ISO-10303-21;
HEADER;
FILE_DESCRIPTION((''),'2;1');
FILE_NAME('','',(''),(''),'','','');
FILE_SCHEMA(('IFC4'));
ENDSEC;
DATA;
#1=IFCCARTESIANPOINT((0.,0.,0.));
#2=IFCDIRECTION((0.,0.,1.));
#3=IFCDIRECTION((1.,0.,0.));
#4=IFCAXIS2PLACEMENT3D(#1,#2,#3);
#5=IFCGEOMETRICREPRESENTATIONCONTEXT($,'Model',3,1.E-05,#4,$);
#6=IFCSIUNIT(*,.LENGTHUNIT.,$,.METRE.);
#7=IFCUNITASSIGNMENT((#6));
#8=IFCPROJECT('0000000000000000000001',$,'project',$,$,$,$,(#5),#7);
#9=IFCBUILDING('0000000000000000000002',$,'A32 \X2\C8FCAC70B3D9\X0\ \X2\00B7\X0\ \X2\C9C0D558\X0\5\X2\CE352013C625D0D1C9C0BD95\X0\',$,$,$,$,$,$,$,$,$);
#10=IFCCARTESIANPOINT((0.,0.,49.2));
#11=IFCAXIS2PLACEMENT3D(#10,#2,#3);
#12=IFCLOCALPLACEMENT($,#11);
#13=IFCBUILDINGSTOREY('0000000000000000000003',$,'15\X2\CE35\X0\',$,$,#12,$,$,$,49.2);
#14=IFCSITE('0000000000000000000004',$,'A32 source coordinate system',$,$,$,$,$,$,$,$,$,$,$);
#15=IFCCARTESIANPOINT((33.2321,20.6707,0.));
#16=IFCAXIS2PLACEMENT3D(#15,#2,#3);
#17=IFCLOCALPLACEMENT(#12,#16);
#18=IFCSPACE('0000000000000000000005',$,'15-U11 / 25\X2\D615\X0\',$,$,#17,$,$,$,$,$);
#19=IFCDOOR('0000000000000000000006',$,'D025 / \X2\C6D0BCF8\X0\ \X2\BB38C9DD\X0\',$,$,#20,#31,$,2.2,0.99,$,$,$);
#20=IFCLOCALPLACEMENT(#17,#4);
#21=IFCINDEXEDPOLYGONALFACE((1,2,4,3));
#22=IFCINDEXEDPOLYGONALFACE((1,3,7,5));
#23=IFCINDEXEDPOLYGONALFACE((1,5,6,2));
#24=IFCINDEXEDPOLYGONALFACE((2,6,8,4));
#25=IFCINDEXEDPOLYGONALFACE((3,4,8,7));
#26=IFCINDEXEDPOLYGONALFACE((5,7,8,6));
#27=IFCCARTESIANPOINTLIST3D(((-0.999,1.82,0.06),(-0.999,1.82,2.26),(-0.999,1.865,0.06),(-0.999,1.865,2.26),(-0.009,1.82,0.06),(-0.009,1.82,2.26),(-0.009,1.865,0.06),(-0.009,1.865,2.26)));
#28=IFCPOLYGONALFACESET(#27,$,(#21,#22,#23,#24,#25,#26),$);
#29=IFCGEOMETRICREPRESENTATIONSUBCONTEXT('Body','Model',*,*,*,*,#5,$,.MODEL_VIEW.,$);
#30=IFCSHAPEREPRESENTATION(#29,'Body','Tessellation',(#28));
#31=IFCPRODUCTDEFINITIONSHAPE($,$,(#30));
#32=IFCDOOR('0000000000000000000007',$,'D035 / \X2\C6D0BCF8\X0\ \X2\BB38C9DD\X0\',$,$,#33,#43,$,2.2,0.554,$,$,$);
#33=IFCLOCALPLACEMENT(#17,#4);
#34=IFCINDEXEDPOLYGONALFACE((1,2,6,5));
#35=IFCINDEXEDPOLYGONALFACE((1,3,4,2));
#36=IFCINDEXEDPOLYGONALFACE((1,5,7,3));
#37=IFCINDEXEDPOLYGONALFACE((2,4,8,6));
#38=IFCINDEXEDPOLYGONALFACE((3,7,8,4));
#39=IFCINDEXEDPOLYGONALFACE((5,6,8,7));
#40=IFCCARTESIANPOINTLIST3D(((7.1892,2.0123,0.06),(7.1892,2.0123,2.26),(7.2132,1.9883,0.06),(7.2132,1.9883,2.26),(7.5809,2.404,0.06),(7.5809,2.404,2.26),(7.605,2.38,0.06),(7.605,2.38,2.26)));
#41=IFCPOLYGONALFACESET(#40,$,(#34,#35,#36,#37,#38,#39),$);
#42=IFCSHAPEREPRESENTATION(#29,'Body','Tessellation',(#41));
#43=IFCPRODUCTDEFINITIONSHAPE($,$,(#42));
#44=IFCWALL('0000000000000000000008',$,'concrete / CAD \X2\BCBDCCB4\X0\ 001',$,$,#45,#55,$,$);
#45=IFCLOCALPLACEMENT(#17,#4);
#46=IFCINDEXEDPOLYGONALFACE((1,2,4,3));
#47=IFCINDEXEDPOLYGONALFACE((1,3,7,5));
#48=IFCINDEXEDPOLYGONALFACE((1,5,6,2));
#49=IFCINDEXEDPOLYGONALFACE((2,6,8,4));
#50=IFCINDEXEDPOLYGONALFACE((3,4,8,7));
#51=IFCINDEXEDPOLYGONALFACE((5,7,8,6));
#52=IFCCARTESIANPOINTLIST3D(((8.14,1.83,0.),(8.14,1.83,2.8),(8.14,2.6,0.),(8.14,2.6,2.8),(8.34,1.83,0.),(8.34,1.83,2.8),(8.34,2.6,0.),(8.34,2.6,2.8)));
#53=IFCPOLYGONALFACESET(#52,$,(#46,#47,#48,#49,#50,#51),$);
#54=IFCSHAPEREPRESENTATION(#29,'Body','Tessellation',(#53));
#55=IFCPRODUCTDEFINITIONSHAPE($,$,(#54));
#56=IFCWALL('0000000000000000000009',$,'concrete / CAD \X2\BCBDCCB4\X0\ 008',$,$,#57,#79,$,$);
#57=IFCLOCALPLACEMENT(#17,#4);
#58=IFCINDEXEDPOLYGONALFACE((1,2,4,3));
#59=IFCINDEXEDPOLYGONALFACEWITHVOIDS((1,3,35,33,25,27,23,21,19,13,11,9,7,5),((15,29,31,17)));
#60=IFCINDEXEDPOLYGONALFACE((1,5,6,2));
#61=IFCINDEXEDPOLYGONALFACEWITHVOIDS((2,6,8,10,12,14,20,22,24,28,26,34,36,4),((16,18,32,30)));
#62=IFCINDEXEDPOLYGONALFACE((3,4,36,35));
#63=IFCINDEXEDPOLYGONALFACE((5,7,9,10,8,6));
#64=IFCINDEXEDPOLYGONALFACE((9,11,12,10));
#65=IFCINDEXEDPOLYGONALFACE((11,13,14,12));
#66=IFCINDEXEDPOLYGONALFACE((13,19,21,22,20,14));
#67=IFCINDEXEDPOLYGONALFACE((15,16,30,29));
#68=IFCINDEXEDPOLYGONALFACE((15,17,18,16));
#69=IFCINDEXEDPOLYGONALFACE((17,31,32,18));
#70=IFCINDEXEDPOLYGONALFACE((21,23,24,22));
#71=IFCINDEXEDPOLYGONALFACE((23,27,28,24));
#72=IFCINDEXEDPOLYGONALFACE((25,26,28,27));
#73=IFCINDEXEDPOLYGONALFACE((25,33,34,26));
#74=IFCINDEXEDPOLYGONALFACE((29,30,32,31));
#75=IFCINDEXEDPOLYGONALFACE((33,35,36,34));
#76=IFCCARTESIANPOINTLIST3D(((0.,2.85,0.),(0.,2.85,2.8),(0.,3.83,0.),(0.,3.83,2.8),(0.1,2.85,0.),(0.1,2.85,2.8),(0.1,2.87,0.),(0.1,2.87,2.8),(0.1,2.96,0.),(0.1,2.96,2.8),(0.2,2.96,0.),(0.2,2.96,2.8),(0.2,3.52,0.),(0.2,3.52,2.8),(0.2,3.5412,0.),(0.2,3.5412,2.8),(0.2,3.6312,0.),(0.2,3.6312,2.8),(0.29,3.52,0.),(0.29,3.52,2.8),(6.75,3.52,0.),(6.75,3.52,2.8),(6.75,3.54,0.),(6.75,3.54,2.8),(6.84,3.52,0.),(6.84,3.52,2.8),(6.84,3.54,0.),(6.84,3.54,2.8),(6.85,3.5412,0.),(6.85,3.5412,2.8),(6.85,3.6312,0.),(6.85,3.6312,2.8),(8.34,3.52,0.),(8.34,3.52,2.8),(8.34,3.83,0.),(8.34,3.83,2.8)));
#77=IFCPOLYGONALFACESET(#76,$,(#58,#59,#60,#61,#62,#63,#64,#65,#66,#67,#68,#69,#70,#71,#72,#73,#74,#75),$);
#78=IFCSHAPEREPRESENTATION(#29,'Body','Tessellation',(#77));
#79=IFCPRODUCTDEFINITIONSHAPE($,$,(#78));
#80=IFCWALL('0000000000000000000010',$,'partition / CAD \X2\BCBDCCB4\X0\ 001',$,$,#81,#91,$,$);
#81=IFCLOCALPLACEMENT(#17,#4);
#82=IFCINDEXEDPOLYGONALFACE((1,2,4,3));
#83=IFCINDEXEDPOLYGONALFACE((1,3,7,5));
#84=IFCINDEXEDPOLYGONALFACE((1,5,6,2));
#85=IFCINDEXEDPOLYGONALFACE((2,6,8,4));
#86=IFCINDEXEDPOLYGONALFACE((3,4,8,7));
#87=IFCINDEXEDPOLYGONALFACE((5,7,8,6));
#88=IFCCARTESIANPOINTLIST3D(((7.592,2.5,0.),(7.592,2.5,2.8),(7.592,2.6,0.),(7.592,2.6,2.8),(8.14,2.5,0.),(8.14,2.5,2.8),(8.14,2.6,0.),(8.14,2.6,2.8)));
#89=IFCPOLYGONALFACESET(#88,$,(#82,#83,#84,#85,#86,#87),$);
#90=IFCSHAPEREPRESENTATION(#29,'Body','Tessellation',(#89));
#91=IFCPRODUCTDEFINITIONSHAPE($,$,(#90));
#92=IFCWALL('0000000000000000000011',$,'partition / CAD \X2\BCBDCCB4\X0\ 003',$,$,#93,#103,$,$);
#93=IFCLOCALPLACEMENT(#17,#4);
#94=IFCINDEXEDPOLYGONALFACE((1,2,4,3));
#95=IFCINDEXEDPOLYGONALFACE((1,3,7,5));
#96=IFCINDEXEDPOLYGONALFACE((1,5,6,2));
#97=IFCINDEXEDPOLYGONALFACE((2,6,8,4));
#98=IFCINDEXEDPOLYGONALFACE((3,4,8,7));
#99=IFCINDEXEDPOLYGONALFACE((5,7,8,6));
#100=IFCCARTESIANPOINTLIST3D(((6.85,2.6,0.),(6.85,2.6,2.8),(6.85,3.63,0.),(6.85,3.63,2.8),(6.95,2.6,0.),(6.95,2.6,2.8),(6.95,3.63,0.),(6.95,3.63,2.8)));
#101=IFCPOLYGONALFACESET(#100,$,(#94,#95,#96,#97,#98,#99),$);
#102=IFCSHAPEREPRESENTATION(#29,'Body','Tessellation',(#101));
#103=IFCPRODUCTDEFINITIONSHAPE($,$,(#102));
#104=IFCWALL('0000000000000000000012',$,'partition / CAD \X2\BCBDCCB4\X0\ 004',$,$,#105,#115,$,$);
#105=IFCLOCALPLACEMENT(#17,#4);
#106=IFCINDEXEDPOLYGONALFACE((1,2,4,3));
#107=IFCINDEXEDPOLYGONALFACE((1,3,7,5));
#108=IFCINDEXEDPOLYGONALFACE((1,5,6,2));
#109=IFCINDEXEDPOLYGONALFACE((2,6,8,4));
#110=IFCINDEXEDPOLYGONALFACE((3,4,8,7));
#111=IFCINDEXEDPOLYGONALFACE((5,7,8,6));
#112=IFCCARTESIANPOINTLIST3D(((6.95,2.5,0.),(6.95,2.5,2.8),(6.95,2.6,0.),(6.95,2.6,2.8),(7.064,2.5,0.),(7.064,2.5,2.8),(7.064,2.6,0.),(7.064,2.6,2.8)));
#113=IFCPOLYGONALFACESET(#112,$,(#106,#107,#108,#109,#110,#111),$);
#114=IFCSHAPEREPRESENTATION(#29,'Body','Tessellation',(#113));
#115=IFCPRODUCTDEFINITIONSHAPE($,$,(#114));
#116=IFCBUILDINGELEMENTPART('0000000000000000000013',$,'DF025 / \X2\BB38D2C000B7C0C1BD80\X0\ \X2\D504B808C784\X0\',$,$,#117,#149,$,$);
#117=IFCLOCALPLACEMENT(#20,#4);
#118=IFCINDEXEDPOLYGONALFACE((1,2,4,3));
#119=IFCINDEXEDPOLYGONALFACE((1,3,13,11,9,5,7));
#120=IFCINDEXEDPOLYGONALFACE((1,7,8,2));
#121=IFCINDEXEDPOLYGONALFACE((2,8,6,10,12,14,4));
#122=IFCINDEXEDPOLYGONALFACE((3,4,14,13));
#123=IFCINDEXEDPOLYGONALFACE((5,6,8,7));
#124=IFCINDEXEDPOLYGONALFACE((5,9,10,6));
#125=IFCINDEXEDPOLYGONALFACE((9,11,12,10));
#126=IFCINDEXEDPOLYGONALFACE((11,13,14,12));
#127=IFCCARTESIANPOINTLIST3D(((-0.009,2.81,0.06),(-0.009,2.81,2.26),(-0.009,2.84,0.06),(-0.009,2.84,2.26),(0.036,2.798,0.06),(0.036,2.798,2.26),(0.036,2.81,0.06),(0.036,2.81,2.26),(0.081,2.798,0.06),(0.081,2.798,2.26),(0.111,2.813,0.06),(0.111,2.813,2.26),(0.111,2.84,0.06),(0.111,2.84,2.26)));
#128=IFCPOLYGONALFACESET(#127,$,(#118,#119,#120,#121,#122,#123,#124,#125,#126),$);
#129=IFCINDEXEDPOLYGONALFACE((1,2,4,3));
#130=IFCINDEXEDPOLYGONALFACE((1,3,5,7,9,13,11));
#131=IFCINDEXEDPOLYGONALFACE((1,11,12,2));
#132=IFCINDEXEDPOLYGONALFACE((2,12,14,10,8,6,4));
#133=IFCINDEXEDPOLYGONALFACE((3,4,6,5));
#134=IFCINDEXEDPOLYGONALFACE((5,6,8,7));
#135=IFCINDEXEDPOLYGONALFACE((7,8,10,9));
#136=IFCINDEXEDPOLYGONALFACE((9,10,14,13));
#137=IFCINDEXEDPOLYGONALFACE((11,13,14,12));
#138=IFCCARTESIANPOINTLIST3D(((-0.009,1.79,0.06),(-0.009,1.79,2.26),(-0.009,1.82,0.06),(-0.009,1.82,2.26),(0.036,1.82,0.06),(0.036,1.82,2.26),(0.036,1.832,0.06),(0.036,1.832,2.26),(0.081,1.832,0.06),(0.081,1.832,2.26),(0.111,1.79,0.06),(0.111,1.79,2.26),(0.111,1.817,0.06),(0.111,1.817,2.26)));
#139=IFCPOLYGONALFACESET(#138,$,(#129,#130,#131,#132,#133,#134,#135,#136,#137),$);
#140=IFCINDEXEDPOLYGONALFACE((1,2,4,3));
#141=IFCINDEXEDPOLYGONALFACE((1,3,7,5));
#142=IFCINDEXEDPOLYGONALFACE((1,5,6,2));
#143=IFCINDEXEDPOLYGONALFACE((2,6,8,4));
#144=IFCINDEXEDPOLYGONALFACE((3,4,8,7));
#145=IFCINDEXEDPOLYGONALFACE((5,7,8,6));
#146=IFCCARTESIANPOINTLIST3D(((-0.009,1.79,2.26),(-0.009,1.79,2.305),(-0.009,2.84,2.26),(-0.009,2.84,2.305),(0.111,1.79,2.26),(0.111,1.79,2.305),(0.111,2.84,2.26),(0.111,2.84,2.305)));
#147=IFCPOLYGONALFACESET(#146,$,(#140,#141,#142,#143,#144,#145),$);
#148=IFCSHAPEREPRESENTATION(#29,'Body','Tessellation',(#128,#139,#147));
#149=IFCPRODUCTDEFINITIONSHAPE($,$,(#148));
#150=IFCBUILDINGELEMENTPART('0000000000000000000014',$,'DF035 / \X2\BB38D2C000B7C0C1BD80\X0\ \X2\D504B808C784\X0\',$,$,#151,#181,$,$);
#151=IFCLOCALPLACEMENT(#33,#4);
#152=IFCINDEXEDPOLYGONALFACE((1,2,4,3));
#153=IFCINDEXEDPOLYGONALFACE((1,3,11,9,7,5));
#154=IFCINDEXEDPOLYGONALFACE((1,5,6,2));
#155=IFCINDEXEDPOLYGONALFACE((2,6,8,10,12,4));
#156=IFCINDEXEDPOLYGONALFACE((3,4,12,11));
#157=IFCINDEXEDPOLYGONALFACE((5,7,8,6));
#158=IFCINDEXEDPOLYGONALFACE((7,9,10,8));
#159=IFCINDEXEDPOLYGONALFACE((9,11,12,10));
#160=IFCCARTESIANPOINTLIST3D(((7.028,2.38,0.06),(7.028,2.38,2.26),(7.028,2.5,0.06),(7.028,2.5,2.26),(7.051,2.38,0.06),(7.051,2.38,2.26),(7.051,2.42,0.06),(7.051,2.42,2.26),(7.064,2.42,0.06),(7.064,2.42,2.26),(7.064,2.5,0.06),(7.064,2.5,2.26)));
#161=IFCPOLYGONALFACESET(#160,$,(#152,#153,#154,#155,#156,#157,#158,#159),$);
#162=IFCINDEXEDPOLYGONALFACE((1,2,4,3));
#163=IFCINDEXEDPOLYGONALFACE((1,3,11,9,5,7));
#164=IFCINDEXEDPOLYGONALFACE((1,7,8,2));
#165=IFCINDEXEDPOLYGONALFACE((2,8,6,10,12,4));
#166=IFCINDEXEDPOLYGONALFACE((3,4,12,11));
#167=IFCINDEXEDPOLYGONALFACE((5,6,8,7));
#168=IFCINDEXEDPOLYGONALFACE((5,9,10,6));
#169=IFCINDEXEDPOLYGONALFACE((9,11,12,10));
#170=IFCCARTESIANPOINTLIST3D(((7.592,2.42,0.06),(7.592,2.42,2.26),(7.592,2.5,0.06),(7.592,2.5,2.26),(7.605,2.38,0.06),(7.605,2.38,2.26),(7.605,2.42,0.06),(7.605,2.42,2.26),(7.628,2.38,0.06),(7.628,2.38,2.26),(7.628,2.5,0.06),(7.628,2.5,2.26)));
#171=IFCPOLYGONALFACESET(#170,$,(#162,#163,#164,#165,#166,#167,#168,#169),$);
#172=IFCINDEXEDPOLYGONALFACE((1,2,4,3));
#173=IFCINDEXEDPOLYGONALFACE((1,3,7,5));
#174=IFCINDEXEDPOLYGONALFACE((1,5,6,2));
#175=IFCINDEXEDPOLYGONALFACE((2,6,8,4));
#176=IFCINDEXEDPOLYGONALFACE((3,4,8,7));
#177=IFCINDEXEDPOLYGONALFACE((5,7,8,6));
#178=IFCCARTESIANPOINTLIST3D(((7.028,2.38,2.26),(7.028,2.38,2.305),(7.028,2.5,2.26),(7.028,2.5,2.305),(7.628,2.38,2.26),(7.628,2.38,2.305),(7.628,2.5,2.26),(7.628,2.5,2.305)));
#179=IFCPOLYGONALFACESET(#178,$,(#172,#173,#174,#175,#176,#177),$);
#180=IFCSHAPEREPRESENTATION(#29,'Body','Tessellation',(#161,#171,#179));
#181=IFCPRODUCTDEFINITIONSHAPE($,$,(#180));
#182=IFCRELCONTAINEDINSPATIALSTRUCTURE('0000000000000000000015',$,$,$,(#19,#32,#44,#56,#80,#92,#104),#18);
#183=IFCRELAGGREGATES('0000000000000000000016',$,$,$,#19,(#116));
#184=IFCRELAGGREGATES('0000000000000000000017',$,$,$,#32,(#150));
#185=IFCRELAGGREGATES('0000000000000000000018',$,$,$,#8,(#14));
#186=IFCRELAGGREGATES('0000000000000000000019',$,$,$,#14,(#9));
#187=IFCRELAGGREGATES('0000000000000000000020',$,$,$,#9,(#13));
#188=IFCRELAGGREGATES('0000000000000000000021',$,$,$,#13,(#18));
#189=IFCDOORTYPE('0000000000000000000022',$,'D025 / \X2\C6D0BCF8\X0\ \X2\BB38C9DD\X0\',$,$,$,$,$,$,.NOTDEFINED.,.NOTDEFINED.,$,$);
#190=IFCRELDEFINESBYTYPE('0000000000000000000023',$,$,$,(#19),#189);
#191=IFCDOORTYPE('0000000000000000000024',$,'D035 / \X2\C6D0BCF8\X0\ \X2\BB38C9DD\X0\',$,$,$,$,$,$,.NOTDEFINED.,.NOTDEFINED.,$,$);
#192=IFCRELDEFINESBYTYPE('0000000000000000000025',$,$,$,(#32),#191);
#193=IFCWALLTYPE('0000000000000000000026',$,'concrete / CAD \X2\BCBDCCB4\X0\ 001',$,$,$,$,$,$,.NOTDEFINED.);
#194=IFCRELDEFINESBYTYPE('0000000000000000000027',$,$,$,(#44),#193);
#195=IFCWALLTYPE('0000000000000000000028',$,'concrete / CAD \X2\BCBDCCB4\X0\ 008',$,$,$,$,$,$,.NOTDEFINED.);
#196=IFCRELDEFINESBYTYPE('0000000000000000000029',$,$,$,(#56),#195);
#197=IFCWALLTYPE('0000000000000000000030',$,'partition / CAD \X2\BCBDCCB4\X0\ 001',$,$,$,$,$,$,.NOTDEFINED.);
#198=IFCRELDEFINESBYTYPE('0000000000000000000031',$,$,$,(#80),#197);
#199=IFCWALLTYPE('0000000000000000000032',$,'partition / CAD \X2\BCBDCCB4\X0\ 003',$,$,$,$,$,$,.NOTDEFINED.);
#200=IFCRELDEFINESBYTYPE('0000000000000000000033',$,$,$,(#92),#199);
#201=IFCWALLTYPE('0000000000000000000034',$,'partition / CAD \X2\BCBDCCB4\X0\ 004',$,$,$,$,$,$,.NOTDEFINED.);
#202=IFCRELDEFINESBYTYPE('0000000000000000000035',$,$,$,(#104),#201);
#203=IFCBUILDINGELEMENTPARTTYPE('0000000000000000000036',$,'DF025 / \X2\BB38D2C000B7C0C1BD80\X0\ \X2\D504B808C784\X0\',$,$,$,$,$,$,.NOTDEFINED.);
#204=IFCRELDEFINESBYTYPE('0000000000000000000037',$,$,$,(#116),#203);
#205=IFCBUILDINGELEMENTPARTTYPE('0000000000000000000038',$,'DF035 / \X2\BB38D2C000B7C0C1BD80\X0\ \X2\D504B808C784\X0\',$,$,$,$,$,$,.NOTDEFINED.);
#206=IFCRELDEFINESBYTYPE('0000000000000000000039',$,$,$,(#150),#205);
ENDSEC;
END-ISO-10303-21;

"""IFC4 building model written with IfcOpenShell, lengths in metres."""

from ifc_helpers import new_model, si_unit, frame, origin, origin_with_axes, place, context, subcontext, project, spatial, polyline, outline, extrude, source, transform, mapped, type_object, type_shapes, element, aggregate, save


model = new_model("IFC4")

# Units and contexts
model_context = context("Model", 3, precision=1e-05, world=origin_with_axes())
body_context = subcontext(model_context, "Body", "Model", "MODEL_VIEW")
ifc_project = project(units=[si_unit("LENGTHUNIT", "METRE")], contexts=[model_context])

# Site, building, storey, space
storey_placement = place(None, frame((0.0, 0.0, 49.2), z_axis=(0.0, 0.0, 1.0), x_axis=(1.0, 0.0, 0.0)))
space_placement = place(storey_placement, frame((33.2321, 20.6707, 0.0), z_axis=(0.0, 0.0, 1.0), x_axis=(1.0, 0.0, 0.0)))
site = spatial("IfcSite", under=ifc_project, Name="A32 source coordinate system")
building = spatial("IfcBuilding", under=site, Name="A32 주거동 · 지하5층–옥탑지붕")
storey = spatial("IfcBuildingStorey", under=building, at=storey_placement, Name="15층", Elevation=49.2)
space = spatial("IfcSpace", under=storey, at=space_placement, Name="15-U11 / 25형")

# Doors
door_type_1 = type_object("IfcDoorType", Name="D025 / 원본 문짝", OperationType="NOTDEFINED", PredefinedType="NOTDEFINED")
shared_shape_1 = source(origin(), body_context, "Body", "SweptSolid", [
    extrude(outline(polyline([(-0.009, 1.82), (-0.999, 1.82), (-0.999, 1.865), (-0.009, 1.865), (-0.009, 1.82)])), frame((0.0, 0.0, 0.06)), (0.0, 0.0, 1.0), 2.2),
])
type_shapes(door_type_1, [shared_shape_1])
door_1_placement = place(space_placement, origin_with_axes())
door_1 = element("IfcDoor", 1, at=door_1_placement, inside=space, type_object=door_type_1, Name="D025 / 원본 문짝", OverallHeight=2.2, OverallWidth=0.99, context=body_context, shape_type="MappedRepresentation", body=[
    mapped(shared_shape_1, transform((0.0, 0.0, 0.0), scale=1.0)),
])
door_type_2 = type_object("IfcDoorType", Name="D035 / 원본 문짝", OperationType="NOTDEFINED", PredefinedType="NOTDEFINED")
shared_shape_2 = source(origin(), body_context, "Body", "SweptSolid", [
    extrude(outline(polyline([(7.605, 2.38), (7.2132, 1.9883), (7.1892, 2.0123), (7.5809, 2.404), (7.605, 2.38)])), frame((0.0, 0.0, 0.06)), (0.0, 0.0, 1.0), 2.2),
])
type_shapes(door_type_2, [shared_shape_2])
door_2_placement = place(space_placement, origin_with_axes())
door_2 = element("IfcDoor", 2, at=door_2_placement, inside=space, type_object=door_type_2, Name="D035 / 원본 문짝", OverallHeight=2.2, OverallWidth=0.554, context=body_context, shape_type="MappedRepresentation", body=[
    mapped(shared_shape_2, transform((0.0, 0.0, 0.0), scale=1.0)),
])

# Walls
wall_type_1 = type_object("IfcWallType", Name="concrete / CAD 벽체 001", PredefinedType="NOTDEFINED")
shared_shape_3 = source(origin(), body_context, "Body", "SweptSolid", [
    extrude(outline(polyline([(8.34, 1.83), (8.14, 1.83), (8.14, 2.6), (8.34, 2.6), (8.34, 1.83)])), origin(), (0.0, 0.0, 1.0), 2.8),
])
type_shapes(wall_type_1, [shared_shape_3])
wall_1_placement = place(space_placement, origin_with_axes())
element("IfcWall", 3, at=wall_1_placement, inside=space, type_object=wall_type_1, Name="concrete / CAD 벽체 001", context=body_context, shape_type="MappedRepresentation", body=[
    mapped(shared_shape_3, transform((0.0, 0.0, 0.0), scale=1.0)),
])
wall_type_2 = type_object("IfcWallType", Name="concrete / CAD 벽체 008", PredefinedType="NOTDEFINED")
shared_shape_4 = source(origin(), body_context, "Body", "SweptSolid", [
    extrude(outline(polyline([(0.0, 3.83), (8.34, 3.83), (8.34, 3.52), (6.84, 3.52), (6.84, 3.54), (6.75, 3.54), (6.75, 3.52), (0.29, 3.52), (0.2, 3.52), (0.2, 2.96), (0.1, 2.96), (0.1, 2.87), (0.1, 2.85), (0.0, 2.85), (0.0, 3.83)]), holes=[polyline([(6.85, 3.5412), (6.85, 3.6312), (0.2, 3.6312), (0.2, 3.5412), (6.85, 3.5412)])]), origin(), (0.0, 0.0, 1.0), 2.8),
])
type_shapes(wall_type_2, [shared_shape_4])
wall_2_placement = place(space_placement, origin_with_axes())
element("IfcWall", 4, at=wall_2_placement, inside=space, type_object=wall_type_2, Name="concrete / CAD 벽체 008", context=body_context, shape_type="MappedRepresentation", body=[
    mapped(shared_shape_4, transform((0.0, 0.0, 0.0), scale=1.0)),
])
wall_type_3 = type_object("IfcWallType", Name="partition / CAD 벽체 001", PredefinedType="NOTDEFINED")
shared_shape_5 = source(origin(), body_context, "Body", "SweptSolid", [
    extrude(outline(polyline([(8.14, 2.6), (8.14, 2.5), (7.592, 2.5), (7.592, 2.6), (8.14, 2.6)])), origin(), (0.0, 0.0, 1.0), 2.8),
])
type_shapes(wall_type_3, [shared_shape_5])
wall_3_placement = place(space_placement, origin_with_axes())
element("IfcWall", 5, at=wall_3_placement, inside=space, type_object=wall_type_3, Name="partition / CAD 벽체 001", context=body_context, shape_type="MappedRepresentation", body=[
    mapped(shared_shape_5, transform((0.0, 0.0, 0.0), scale=1.0)),
])
wall_type_4 = type_object("IfcWallType", Name="partition / CAD 벽체 003", PredefinedType="NOTDEFINED")
shared_shape_6 = source(origin(), body_context, "Body", "SweptSolid", [
    extrude(outline(polyline([(6.85, 2.6), (6.85, 3.63), (6.95, 3.63), (6.95, 2.6), (6.85, 2.6)])), origin(), (0.0, 0.0, 1.0), 2.8),
])
type_shapes(wall_type_4, [shared_shape_6])
wall_4_placement = place(space_placement, origin_with_axes())
element("IfcWall", 6, at=wall_4_placement, inside=space, type_object=wall_type_4, Name="partition / CAD 벽체 003", context=body_context, shape_type="MappedRepresentation", body=[
    mapped(shared_shape_6, transform((0.0, 0.0, 0.0), scale=1.0)),
])
wall_type_5 = type_object("IfcWallType", Name="partition / CAD 벽체 004", PredefinedType="NOTDEFINED")
shared_shape_7 = source(origin(), body_context, "Body", "SweptSolid", [
    extrude(outline(polyline([(6.95, 2.5), (6.95, 2.6), (7.064, 2.6), (7.064, 2.5), (6.95, 2.5)])), origin(), (0.0, 0.0, 1.0), 2.8),
])
type_shapes(wall_type_5, [shared_shape_7])
wall_5_placement = place(space_placement, origin_with_axes())
element("IfcWall", 7, at=wall_5_placement, inside=space, type_object=wall_type_5, Name="partition / CAD 벽체 004", context=body_context, shape_type="MappedRepresentation", body=[
    mapped(shared_shape_7, transform((0.0, 0.0, 0.0), scale=1.0)),
])

# Building element parts
building_element_part_type_1 = type_object("IfcBuildingElementPartType", Name="DF025 / 문틀·상부 프레임", PredefinedType="NOTDEFINED")
shared_shape_8 = source(origin(), body_context, "Body", "SweptSolid", [
    extrude(outline(polyline([(0.111, 2.84), (0.111, 2.813), (0.081, 2.798), (0.036, 2.798), (0.036, 2.81), (-0.009, 2.81), (-0.009, 2.84), (0.111, 2.84)])), frame((0.0, 0.0, 0.06)), (0.0, 0.0, 1.0), 2.2),
    extrude(outline(polyline([(-0.009, 1.82), (0.036, 1.82), (0.036, 1.832), (0.081, 1.832), (0.111, 1.817), (0.111, 1.79), (-0.009, 1.79), (-0.009, 1.82)])), frame((0.0, 0.0, 0.06)), (0.0, 0.0, 1.0), 2.2),
    extrude(outline(polyline([(-0.009, 1.79), (-0.009, 2.84), (0.111, 2.84), (0.111, 1.79), (-0.009, 1.79)])), frame((0.0, 0.0, 2.26)), (0.0, 0.0, 1.0), 0.045),
])
type_shapes(building_element_part_type_1, [shared_shape_8])
building_element_part_1_placement = place(door_1_placement, origin_with_axes())
building_element_part_1 = element("IfcBuildingElementPart", 8, at=building_element_part_1_placement, type_object=building_element_part_type_1, Name="DF025 / 문틀·상부 프레임", context=body_context, shape_type="MappedRepresentation", body=[
    mapped(shared_shape_8, transform((0.0, 0.0, 0.0), scale=1.0)),
])
aggregate(door_1, [building_element_part_1])
building_element_part_type_2 = type_object("IfcBuildingElementPartType", Name="DF035 / 문틀·상부 프레임", PredefinedType="NOTDEFINED")
shared_shape_9 = source(origin(), body_context, "Body", "SweptSolid", [
    extrude(outline(polyline([(7.064, 2.5), (7.064, 2.42), (7.051, 2.42), (7.051, 2.38), (7.028, 2.38), (7.028, 2.5), (7.064, 2.5)])), frame((0.0, 0.0, 0.06)), (0.0, 0.0, 1.0), 2.2),
    extrude(outline(polyline([(7.628, 2.38), (7.605, 2.38), (7.605, 2.42), (7.592, 2.42), (7.592, 2.5), (7.628, 2.5), (7.628, 2.38)])), frame((0.0, 0.0, 0.06)), (0.0, 0.0, 1.0), 2.2),
    extrude(outline(polyline([(7.028, 2.38), (7.028, 2.5), (7.628, 2.5), (7.628, 2.38), (7.028, 2.38)])), frame((0.0, 0.0, 2.26)), (0.0, 0.0, 1.0), 0.045),
])
type_shapes(building_element_part_type_2, [shared_shape_9])
building_element_part_2_placement = place(door_2_placement, origin_with_axes())
building_element_part_2 = element("IfcBuildingElementPart", 9, at=building_element_part_2_placement, type_object=building_element_part_type_2, Name="DF035 / 문틀·상부 프레임", context=body_context, shape_type="MappedRepresentation", body=[
    mapped(shared_shape_9, transform((0.0, 0.0, 0.0), scale=1.0)),
])
aggregate(door_2, [building_element_part_2])

save(model, "model.ifc")
